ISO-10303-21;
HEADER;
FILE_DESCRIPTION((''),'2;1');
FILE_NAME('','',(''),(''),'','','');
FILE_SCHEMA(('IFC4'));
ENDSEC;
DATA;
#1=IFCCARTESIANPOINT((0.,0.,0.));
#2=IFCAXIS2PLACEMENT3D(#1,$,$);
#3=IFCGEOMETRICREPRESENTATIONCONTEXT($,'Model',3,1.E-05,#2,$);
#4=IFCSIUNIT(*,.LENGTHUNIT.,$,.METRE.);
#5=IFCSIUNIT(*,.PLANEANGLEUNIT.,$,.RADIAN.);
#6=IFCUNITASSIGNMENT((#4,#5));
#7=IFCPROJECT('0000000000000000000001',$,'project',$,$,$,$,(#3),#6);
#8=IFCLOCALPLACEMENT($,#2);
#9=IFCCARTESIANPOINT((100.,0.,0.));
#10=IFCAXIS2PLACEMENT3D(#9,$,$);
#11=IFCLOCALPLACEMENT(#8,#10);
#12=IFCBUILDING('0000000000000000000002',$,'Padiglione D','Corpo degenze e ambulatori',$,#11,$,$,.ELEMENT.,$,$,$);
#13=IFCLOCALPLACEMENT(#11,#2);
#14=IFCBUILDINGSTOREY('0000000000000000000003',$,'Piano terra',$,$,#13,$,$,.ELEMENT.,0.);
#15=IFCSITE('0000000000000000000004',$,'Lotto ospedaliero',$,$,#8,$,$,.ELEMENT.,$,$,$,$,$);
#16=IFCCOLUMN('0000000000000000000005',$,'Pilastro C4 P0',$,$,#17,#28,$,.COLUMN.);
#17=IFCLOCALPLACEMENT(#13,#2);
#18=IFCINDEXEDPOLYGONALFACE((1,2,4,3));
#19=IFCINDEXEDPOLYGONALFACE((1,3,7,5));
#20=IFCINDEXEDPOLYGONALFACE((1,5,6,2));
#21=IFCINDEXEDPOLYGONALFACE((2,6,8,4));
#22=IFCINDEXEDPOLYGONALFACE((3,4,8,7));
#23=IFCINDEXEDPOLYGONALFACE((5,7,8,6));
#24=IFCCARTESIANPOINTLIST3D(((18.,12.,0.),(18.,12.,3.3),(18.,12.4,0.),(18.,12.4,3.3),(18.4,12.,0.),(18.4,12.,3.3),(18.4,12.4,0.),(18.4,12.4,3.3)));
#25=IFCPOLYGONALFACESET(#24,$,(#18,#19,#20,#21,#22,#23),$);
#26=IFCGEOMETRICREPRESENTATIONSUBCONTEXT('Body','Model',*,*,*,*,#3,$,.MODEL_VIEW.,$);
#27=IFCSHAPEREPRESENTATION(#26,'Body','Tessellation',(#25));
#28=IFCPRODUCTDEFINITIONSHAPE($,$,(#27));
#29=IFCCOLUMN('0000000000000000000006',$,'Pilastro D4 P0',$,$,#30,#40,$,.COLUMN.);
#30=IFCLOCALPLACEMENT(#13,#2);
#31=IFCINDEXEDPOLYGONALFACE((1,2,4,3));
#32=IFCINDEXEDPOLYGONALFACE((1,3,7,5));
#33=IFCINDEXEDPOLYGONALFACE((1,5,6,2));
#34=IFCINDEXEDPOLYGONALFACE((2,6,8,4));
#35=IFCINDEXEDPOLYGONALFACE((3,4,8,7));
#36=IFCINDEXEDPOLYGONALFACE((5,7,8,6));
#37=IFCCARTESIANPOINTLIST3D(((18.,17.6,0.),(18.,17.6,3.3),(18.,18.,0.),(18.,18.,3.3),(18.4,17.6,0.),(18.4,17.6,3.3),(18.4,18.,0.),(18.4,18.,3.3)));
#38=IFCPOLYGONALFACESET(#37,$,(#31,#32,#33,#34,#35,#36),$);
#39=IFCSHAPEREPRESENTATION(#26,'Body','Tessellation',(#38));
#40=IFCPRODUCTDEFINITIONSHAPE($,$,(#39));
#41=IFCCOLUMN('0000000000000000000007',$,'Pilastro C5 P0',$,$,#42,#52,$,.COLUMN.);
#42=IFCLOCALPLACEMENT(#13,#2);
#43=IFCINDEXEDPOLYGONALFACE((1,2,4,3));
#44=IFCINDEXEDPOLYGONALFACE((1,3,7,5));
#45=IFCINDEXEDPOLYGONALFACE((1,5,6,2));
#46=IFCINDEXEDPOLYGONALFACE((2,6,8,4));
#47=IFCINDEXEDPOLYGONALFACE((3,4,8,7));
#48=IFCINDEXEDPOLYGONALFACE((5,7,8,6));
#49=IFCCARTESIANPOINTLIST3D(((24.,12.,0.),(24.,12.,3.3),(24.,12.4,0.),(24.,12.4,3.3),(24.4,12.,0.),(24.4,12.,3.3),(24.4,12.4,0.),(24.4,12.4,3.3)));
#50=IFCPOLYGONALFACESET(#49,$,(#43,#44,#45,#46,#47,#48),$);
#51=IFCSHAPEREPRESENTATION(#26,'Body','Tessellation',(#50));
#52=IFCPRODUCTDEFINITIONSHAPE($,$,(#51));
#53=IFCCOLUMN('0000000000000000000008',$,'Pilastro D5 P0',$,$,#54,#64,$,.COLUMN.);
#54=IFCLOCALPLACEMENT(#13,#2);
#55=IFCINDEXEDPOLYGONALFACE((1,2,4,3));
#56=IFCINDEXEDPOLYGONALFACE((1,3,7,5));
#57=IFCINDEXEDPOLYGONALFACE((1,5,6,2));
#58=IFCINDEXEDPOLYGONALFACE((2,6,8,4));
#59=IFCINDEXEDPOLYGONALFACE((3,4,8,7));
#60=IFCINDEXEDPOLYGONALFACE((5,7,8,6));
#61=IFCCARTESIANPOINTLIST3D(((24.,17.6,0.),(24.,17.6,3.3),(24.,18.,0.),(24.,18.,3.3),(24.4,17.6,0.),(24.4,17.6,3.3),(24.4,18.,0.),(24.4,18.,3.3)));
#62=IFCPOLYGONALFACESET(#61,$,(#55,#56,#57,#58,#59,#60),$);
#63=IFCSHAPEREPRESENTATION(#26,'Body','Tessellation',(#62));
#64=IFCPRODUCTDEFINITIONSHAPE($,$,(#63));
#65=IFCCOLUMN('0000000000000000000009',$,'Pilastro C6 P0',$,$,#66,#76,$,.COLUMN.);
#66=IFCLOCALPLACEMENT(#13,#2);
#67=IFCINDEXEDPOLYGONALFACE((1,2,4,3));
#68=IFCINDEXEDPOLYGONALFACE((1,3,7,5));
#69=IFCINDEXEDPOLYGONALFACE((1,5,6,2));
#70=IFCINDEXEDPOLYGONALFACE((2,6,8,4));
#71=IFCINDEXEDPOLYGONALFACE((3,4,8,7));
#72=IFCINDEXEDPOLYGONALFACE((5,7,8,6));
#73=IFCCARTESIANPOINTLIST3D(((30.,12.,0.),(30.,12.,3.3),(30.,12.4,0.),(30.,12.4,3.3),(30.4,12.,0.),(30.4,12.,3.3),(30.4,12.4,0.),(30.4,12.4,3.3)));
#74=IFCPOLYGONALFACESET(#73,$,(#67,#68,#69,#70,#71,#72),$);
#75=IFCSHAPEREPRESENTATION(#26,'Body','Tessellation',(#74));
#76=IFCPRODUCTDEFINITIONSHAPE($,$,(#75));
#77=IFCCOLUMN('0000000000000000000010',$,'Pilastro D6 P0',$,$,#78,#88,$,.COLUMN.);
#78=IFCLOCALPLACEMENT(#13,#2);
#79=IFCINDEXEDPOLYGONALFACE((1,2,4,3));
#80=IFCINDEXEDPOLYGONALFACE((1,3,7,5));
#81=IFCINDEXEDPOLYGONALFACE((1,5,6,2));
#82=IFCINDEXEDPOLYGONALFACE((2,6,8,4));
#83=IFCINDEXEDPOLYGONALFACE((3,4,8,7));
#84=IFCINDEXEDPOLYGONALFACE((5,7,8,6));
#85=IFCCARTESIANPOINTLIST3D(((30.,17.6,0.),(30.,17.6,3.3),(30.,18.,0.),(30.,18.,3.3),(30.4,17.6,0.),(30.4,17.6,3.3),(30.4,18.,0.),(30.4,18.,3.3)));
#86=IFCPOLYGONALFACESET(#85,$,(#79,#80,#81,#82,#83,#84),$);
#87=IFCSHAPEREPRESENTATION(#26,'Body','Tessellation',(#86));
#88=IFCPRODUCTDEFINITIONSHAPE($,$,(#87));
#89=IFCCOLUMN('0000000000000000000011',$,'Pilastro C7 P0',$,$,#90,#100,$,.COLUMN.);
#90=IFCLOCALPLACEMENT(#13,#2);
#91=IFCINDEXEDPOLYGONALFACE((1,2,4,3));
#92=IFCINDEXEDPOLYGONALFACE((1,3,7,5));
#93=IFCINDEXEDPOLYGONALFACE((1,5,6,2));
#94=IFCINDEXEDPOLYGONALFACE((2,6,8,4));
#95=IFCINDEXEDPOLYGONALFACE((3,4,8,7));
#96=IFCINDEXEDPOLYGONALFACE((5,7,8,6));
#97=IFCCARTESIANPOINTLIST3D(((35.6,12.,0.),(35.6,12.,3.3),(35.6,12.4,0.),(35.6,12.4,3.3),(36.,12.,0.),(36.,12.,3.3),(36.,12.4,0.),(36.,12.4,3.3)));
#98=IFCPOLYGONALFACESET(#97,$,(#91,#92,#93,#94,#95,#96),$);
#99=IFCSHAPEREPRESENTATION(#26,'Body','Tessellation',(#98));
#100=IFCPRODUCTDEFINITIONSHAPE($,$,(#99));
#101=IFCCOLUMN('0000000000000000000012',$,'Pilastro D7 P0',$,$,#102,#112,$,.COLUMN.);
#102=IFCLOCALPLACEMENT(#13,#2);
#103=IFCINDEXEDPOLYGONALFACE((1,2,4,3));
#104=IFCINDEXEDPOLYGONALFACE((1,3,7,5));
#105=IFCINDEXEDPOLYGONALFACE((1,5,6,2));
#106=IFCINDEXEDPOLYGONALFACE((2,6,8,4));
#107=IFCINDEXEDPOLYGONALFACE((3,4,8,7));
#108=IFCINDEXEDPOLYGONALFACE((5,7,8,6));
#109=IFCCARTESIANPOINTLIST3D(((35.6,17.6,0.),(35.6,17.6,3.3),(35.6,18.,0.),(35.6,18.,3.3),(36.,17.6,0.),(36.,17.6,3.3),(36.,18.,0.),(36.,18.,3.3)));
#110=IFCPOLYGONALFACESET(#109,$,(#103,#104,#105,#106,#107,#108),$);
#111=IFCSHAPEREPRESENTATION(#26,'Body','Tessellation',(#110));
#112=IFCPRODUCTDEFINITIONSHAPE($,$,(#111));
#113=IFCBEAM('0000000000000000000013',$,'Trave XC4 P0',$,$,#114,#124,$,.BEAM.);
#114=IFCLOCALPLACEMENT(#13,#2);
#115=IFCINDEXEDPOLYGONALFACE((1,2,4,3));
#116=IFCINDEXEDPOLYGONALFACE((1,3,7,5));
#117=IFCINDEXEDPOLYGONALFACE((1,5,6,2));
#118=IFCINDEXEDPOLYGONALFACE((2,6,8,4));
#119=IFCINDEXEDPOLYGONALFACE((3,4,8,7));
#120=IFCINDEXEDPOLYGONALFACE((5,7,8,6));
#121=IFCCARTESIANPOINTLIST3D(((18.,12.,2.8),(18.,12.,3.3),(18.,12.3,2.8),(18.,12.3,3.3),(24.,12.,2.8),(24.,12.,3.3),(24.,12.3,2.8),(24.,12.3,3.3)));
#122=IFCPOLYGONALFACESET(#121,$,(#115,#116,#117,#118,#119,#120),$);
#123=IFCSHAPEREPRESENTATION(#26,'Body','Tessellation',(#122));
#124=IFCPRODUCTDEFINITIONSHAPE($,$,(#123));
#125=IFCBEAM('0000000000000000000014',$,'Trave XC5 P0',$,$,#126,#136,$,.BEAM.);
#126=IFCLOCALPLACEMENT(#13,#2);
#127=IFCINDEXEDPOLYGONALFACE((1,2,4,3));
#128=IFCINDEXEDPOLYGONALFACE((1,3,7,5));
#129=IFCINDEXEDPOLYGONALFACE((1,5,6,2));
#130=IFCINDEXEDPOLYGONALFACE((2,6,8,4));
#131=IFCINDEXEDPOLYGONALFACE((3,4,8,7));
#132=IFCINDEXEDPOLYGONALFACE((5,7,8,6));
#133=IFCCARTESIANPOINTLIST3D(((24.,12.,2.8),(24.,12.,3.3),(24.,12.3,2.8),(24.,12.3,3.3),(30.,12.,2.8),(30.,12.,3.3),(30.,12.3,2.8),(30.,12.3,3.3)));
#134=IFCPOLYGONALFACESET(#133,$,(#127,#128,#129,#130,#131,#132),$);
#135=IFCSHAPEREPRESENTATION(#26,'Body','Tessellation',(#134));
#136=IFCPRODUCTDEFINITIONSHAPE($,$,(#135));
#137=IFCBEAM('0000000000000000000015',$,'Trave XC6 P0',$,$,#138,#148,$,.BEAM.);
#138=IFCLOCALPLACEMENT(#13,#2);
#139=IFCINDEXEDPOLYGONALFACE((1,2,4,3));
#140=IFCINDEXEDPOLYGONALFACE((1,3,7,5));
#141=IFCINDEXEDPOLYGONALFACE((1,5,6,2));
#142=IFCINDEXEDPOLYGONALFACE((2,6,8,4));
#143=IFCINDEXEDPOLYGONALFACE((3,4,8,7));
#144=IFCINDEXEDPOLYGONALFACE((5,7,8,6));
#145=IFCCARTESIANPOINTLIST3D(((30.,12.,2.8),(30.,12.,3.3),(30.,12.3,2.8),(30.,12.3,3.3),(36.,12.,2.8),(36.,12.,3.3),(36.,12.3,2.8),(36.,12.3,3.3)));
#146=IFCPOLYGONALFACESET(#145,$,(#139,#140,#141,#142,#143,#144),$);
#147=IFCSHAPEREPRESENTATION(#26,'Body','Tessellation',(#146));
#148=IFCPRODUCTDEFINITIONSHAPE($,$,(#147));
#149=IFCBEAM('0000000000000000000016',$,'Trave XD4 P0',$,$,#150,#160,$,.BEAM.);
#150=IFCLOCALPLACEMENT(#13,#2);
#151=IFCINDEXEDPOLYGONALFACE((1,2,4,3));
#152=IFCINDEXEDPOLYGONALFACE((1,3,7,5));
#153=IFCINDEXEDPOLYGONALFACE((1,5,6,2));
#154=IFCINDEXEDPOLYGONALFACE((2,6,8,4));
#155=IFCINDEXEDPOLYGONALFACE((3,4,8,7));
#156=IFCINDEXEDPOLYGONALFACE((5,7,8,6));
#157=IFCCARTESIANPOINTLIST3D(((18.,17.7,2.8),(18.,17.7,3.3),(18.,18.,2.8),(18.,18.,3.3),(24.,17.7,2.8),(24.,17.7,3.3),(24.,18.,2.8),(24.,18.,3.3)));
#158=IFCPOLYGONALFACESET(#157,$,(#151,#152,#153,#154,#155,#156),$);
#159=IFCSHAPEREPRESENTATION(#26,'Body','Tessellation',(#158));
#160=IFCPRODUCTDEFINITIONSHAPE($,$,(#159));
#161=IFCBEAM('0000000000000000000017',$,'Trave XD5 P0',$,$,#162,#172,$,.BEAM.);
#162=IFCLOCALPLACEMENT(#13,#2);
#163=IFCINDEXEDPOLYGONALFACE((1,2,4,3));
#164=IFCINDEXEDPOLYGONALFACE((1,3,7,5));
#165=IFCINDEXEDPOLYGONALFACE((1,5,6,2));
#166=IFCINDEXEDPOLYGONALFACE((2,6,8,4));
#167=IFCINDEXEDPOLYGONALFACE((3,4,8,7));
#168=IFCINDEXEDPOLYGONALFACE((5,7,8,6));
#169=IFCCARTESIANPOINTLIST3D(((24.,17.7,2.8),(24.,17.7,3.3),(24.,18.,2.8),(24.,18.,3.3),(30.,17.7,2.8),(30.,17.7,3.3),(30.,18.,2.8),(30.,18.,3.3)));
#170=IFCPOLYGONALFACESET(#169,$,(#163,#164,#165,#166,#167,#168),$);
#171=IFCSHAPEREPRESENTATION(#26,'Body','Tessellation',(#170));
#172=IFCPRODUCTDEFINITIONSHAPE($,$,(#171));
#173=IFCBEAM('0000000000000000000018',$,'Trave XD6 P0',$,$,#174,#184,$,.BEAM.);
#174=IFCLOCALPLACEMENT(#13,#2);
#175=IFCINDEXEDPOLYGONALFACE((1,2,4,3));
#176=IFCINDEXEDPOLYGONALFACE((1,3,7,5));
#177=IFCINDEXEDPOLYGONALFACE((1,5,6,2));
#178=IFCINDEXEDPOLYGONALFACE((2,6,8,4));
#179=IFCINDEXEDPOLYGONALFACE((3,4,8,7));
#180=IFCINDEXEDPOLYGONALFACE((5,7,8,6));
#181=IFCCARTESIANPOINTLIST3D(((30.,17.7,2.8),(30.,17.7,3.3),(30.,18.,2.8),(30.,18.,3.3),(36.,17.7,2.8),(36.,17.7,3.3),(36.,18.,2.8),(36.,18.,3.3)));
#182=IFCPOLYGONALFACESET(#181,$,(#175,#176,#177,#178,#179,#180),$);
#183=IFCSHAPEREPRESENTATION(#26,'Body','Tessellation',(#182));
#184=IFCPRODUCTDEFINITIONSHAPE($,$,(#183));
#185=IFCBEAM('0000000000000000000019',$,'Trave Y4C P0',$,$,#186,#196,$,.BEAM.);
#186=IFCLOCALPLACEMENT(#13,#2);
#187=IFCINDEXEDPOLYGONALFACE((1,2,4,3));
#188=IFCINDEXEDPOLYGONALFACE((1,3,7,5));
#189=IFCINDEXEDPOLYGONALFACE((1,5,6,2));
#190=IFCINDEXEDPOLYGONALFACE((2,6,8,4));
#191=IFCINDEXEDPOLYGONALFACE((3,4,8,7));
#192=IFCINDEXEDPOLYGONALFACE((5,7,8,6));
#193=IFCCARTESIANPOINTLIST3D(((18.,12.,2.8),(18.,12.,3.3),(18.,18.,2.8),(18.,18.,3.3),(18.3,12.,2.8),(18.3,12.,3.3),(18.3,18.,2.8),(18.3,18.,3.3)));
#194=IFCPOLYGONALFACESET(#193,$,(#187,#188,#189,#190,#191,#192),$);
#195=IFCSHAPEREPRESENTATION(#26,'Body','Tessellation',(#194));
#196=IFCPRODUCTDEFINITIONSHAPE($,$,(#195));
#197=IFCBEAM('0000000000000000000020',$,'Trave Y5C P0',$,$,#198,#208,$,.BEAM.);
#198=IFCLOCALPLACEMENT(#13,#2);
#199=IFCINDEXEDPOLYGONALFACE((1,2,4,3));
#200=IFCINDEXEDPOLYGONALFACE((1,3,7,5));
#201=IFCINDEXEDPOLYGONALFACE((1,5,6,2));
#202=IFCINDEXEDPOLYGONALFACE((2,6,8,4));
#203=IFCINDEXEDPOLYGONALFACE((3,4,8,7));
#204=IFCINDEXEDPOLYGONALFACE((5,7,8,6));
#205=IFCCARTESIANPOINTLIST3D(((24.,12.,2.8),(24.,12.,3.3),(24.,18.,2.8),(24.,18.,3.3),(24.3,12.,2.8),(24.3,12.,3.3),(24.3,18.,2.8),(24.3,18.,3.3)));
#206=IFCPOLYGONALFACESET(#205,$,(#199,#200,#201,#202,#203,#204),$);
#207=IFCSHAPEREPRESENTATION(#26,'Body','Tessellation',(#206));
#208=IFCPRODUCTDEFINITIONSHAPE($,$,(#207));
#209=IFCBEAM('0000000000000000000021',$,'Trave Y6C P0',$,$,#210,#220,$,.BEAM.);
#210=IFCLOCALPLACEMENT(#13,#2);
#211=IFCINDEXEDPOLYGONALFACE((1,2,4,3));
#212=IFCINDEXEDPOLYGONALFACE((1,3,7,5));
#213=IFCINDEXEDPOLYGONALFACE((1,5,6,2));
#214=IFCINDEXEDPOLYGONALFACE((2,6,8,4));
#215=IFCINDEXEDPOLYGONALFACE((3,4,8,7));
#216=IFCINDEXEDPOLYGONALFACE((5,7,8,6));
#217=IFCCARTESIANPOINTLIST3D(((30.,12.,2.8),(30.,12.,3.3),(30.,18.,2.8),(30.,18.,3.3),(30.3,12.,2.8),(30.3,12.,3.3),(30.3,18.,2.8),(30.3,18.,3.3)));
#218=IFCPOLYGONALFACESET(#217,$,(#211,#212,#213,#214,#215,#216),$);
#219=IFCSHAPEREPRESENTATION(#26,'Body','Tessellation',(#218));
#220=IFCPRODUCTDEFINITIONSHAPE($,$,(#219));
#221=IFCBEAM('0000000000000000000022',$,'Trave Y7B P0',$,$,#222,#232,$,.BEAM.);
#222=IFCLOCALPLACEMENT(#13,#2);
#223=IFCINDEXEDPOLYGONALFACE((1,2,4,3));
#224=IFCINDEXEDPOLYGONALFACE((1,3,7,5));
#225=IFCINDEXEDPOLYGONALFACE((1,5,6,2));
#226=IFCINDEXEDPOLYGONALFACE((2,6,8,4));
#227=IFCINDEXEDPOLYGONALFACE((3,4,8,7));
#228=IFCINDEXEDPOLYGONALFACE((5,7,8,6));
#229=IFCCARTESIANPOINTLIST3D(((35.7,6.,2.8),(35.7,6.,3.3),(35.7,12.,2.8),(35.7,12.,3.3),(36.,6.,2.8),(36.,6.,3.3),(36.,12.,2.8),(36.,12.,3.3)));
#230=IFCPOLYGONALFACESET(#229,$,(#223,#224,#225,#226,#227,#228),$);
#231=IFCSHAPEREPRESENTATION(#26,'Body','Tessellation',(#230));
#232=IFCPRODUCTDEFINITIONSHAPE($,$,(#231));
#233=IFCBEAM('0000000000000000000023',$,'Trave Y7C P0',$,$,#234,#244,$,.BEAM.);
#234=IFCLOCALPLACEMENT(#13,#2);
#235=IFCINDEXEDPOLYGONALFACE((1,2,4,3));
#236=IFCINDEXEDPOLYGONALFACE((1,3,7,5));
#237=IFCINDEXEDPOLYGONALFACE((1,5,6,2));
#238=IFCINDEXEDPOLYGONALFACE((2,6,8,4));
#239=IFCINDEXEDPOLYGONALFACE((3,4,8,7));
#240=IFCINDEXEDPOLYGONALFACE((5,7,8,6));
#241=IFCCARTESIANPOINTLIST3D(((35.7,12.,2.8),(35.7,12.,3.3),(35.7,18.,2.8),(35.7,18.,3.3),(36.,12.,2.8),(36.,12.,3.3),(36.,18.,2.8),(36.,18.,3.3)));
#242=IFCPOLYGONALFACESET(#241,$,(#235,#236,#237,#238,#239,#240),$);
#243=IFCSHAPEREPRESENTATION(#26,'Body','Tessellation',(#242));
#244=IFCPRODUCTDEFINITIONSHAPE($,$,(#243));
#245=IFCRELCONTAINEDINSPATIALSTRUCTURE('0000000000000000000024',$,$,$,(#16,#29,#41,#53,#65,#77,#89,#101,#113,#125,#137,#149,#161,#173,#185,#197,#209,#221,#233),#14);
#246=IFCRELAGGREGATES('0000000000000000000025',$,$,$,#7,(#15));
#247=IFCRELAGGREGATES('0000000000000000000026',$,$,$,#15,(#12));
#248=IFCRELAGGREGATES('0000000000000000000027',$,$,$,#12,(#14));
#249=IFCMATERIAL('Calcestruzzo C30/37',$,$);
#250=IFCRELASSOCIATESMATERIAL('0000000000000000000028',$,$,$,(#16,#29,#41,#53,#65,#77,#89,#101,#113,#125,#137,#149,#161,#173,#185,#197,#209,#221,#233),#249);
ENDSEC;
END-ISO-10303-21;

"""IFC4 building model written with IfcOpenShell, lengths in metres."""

from ifc_helpers import new_model, si_unit, frame, frame_2d, origin, place, context, subcontext, project, spatial, rectangle, extrude, material, element, save


model = new_model("IFC4")

# Units and contexts
model_context = context("Model", 3, precision=1e-05, world=origin())
body_context = subcontext(model_context, "Body", "Model", "MODEL_VIEW")
ifc_project = project(units=[si_unit("LENGTHUNIT", "METRE"), si_unit("PLANEANGLEUNIT", "RADIAN")], contexts=[model_context])

# Site, building, storey
site_placement = place(None, origin())
site = spatial("IfcSite", under=ifc_project, at=site_placement, Name="Lotto ospedaliero", CompositionType="ELEMENT")
building_placement = place(site_placement, frame((100.0, 0.0, 0.0)))
building = spatial("IfcBuilding", under=site, at=building_placement, Name="Padiglione D", Description="Corpo degenze e ambulatori", CompositionType="ELEMENT")
storey_placement = place(building_placement, origin())
storey = spatial("IfcBuildingStorey", under=building, at=storey_placement, Name="Piano terra", CompositionType="ELEMENT", Elevation=0.0)

# Columns
ifc_material_1 = material(Name="Calcestruzzo C30/37")
for number, where, name in (
    (1, (18.0, 12.0, 0.0), "Pilastro C4 P0"),
    (2, (18.0, 17.6, 0.0), "Pilastro D4 P0"),
    (3, (24.0, 12.0, 0.0), "Pilastro C5 P0"),
    (4, (24.0, 17.6, 0.0), "Pilastro D5 P0"),
    (5, (30.0, 12.0, 0.0), "Pilastro C6 P0"),
    (6, (30.0, 17.6, 0.0), "Pilastro D6 P0"),
    (7, (35.6, 12.0, 0.0), "Pilastro C7 P0"),
    (8, (35.6, 17.6, 0.0), "Pilastro D7 P0"),
):
    element("IfcColumn", number, at=place(storey_placement, frame(where)), inside=storey, material=ifc_material_1, Name=name, PredefinedType="COLUMN", context=body_context, shape_type="SweptSolid", body=[
        extrude(rectangle(XDim=0.4, YDim=0.4, at=frame_2d((0.2, 0.2))), origin(), (0.0, 0.0, 1.0), 3.3),
    ])

# Beams
for number, where, name in (
    (9, (18.0, 12.0, 2.8), "Trave XC4 P0"),
    (10, (24.0, 12.0, 2.8), "Trave XC5 P0"),
    (11, (30.0, 12.0, 2.8), "Trave XC6 P0"),
    (12, (18.0, 17.7, 2.8), "Trave XD4 P0"),
    (13, (24.0, 17.7, 2.8), "Trave XD5 P0"),
    (14, (30.0, 17.7, 2.8), "Trave XD6 P0"),
):
    element("IfcBeam", number, at=place(storey_placement, frame(where)), inside=storey, material=ifc_material_1, Name=name, PredefinedType="BEAM", context=body_context, shape_type="SweptSolid", body=[
        extrude(rectangle(XDim=6.0, YDim=0.3, at=frame_2d((3.0, 0.15))), origin(), (0.0, 0.0, 1.0), 0.5),
    ])
for number, where, name in (
    (15, (18.0, 12.0, 2.8), "Trave Y4C P0"),
    (16, (24.0, 12.0, 2.8), "Trave Y5C P0"),
    (17, (30.0, 12.0, 2.8), "Trave Y6C P0"),
    (18, (35.7, 6.0, 2.8), "Trave Y7B P0"),
    (19, (35.7, 12.0, 2.8), "Trave Y7C P0"),
):
    element("IfcBeam", number, at=place(storey_placement, frame(where)), inside=storey, material=ifc_material_1, Name=name, PredefinedType="BEAM", context=body_context, shape_type="SweptSolid", body=[
        extrude(rectangle(XDim=0.3, YDim=6.0, at=frame_2d((0.15, 3.0))), origin(), (0.0, 0.0, 1.0), 0.5),
    ])

save(model, "model.ifc")
